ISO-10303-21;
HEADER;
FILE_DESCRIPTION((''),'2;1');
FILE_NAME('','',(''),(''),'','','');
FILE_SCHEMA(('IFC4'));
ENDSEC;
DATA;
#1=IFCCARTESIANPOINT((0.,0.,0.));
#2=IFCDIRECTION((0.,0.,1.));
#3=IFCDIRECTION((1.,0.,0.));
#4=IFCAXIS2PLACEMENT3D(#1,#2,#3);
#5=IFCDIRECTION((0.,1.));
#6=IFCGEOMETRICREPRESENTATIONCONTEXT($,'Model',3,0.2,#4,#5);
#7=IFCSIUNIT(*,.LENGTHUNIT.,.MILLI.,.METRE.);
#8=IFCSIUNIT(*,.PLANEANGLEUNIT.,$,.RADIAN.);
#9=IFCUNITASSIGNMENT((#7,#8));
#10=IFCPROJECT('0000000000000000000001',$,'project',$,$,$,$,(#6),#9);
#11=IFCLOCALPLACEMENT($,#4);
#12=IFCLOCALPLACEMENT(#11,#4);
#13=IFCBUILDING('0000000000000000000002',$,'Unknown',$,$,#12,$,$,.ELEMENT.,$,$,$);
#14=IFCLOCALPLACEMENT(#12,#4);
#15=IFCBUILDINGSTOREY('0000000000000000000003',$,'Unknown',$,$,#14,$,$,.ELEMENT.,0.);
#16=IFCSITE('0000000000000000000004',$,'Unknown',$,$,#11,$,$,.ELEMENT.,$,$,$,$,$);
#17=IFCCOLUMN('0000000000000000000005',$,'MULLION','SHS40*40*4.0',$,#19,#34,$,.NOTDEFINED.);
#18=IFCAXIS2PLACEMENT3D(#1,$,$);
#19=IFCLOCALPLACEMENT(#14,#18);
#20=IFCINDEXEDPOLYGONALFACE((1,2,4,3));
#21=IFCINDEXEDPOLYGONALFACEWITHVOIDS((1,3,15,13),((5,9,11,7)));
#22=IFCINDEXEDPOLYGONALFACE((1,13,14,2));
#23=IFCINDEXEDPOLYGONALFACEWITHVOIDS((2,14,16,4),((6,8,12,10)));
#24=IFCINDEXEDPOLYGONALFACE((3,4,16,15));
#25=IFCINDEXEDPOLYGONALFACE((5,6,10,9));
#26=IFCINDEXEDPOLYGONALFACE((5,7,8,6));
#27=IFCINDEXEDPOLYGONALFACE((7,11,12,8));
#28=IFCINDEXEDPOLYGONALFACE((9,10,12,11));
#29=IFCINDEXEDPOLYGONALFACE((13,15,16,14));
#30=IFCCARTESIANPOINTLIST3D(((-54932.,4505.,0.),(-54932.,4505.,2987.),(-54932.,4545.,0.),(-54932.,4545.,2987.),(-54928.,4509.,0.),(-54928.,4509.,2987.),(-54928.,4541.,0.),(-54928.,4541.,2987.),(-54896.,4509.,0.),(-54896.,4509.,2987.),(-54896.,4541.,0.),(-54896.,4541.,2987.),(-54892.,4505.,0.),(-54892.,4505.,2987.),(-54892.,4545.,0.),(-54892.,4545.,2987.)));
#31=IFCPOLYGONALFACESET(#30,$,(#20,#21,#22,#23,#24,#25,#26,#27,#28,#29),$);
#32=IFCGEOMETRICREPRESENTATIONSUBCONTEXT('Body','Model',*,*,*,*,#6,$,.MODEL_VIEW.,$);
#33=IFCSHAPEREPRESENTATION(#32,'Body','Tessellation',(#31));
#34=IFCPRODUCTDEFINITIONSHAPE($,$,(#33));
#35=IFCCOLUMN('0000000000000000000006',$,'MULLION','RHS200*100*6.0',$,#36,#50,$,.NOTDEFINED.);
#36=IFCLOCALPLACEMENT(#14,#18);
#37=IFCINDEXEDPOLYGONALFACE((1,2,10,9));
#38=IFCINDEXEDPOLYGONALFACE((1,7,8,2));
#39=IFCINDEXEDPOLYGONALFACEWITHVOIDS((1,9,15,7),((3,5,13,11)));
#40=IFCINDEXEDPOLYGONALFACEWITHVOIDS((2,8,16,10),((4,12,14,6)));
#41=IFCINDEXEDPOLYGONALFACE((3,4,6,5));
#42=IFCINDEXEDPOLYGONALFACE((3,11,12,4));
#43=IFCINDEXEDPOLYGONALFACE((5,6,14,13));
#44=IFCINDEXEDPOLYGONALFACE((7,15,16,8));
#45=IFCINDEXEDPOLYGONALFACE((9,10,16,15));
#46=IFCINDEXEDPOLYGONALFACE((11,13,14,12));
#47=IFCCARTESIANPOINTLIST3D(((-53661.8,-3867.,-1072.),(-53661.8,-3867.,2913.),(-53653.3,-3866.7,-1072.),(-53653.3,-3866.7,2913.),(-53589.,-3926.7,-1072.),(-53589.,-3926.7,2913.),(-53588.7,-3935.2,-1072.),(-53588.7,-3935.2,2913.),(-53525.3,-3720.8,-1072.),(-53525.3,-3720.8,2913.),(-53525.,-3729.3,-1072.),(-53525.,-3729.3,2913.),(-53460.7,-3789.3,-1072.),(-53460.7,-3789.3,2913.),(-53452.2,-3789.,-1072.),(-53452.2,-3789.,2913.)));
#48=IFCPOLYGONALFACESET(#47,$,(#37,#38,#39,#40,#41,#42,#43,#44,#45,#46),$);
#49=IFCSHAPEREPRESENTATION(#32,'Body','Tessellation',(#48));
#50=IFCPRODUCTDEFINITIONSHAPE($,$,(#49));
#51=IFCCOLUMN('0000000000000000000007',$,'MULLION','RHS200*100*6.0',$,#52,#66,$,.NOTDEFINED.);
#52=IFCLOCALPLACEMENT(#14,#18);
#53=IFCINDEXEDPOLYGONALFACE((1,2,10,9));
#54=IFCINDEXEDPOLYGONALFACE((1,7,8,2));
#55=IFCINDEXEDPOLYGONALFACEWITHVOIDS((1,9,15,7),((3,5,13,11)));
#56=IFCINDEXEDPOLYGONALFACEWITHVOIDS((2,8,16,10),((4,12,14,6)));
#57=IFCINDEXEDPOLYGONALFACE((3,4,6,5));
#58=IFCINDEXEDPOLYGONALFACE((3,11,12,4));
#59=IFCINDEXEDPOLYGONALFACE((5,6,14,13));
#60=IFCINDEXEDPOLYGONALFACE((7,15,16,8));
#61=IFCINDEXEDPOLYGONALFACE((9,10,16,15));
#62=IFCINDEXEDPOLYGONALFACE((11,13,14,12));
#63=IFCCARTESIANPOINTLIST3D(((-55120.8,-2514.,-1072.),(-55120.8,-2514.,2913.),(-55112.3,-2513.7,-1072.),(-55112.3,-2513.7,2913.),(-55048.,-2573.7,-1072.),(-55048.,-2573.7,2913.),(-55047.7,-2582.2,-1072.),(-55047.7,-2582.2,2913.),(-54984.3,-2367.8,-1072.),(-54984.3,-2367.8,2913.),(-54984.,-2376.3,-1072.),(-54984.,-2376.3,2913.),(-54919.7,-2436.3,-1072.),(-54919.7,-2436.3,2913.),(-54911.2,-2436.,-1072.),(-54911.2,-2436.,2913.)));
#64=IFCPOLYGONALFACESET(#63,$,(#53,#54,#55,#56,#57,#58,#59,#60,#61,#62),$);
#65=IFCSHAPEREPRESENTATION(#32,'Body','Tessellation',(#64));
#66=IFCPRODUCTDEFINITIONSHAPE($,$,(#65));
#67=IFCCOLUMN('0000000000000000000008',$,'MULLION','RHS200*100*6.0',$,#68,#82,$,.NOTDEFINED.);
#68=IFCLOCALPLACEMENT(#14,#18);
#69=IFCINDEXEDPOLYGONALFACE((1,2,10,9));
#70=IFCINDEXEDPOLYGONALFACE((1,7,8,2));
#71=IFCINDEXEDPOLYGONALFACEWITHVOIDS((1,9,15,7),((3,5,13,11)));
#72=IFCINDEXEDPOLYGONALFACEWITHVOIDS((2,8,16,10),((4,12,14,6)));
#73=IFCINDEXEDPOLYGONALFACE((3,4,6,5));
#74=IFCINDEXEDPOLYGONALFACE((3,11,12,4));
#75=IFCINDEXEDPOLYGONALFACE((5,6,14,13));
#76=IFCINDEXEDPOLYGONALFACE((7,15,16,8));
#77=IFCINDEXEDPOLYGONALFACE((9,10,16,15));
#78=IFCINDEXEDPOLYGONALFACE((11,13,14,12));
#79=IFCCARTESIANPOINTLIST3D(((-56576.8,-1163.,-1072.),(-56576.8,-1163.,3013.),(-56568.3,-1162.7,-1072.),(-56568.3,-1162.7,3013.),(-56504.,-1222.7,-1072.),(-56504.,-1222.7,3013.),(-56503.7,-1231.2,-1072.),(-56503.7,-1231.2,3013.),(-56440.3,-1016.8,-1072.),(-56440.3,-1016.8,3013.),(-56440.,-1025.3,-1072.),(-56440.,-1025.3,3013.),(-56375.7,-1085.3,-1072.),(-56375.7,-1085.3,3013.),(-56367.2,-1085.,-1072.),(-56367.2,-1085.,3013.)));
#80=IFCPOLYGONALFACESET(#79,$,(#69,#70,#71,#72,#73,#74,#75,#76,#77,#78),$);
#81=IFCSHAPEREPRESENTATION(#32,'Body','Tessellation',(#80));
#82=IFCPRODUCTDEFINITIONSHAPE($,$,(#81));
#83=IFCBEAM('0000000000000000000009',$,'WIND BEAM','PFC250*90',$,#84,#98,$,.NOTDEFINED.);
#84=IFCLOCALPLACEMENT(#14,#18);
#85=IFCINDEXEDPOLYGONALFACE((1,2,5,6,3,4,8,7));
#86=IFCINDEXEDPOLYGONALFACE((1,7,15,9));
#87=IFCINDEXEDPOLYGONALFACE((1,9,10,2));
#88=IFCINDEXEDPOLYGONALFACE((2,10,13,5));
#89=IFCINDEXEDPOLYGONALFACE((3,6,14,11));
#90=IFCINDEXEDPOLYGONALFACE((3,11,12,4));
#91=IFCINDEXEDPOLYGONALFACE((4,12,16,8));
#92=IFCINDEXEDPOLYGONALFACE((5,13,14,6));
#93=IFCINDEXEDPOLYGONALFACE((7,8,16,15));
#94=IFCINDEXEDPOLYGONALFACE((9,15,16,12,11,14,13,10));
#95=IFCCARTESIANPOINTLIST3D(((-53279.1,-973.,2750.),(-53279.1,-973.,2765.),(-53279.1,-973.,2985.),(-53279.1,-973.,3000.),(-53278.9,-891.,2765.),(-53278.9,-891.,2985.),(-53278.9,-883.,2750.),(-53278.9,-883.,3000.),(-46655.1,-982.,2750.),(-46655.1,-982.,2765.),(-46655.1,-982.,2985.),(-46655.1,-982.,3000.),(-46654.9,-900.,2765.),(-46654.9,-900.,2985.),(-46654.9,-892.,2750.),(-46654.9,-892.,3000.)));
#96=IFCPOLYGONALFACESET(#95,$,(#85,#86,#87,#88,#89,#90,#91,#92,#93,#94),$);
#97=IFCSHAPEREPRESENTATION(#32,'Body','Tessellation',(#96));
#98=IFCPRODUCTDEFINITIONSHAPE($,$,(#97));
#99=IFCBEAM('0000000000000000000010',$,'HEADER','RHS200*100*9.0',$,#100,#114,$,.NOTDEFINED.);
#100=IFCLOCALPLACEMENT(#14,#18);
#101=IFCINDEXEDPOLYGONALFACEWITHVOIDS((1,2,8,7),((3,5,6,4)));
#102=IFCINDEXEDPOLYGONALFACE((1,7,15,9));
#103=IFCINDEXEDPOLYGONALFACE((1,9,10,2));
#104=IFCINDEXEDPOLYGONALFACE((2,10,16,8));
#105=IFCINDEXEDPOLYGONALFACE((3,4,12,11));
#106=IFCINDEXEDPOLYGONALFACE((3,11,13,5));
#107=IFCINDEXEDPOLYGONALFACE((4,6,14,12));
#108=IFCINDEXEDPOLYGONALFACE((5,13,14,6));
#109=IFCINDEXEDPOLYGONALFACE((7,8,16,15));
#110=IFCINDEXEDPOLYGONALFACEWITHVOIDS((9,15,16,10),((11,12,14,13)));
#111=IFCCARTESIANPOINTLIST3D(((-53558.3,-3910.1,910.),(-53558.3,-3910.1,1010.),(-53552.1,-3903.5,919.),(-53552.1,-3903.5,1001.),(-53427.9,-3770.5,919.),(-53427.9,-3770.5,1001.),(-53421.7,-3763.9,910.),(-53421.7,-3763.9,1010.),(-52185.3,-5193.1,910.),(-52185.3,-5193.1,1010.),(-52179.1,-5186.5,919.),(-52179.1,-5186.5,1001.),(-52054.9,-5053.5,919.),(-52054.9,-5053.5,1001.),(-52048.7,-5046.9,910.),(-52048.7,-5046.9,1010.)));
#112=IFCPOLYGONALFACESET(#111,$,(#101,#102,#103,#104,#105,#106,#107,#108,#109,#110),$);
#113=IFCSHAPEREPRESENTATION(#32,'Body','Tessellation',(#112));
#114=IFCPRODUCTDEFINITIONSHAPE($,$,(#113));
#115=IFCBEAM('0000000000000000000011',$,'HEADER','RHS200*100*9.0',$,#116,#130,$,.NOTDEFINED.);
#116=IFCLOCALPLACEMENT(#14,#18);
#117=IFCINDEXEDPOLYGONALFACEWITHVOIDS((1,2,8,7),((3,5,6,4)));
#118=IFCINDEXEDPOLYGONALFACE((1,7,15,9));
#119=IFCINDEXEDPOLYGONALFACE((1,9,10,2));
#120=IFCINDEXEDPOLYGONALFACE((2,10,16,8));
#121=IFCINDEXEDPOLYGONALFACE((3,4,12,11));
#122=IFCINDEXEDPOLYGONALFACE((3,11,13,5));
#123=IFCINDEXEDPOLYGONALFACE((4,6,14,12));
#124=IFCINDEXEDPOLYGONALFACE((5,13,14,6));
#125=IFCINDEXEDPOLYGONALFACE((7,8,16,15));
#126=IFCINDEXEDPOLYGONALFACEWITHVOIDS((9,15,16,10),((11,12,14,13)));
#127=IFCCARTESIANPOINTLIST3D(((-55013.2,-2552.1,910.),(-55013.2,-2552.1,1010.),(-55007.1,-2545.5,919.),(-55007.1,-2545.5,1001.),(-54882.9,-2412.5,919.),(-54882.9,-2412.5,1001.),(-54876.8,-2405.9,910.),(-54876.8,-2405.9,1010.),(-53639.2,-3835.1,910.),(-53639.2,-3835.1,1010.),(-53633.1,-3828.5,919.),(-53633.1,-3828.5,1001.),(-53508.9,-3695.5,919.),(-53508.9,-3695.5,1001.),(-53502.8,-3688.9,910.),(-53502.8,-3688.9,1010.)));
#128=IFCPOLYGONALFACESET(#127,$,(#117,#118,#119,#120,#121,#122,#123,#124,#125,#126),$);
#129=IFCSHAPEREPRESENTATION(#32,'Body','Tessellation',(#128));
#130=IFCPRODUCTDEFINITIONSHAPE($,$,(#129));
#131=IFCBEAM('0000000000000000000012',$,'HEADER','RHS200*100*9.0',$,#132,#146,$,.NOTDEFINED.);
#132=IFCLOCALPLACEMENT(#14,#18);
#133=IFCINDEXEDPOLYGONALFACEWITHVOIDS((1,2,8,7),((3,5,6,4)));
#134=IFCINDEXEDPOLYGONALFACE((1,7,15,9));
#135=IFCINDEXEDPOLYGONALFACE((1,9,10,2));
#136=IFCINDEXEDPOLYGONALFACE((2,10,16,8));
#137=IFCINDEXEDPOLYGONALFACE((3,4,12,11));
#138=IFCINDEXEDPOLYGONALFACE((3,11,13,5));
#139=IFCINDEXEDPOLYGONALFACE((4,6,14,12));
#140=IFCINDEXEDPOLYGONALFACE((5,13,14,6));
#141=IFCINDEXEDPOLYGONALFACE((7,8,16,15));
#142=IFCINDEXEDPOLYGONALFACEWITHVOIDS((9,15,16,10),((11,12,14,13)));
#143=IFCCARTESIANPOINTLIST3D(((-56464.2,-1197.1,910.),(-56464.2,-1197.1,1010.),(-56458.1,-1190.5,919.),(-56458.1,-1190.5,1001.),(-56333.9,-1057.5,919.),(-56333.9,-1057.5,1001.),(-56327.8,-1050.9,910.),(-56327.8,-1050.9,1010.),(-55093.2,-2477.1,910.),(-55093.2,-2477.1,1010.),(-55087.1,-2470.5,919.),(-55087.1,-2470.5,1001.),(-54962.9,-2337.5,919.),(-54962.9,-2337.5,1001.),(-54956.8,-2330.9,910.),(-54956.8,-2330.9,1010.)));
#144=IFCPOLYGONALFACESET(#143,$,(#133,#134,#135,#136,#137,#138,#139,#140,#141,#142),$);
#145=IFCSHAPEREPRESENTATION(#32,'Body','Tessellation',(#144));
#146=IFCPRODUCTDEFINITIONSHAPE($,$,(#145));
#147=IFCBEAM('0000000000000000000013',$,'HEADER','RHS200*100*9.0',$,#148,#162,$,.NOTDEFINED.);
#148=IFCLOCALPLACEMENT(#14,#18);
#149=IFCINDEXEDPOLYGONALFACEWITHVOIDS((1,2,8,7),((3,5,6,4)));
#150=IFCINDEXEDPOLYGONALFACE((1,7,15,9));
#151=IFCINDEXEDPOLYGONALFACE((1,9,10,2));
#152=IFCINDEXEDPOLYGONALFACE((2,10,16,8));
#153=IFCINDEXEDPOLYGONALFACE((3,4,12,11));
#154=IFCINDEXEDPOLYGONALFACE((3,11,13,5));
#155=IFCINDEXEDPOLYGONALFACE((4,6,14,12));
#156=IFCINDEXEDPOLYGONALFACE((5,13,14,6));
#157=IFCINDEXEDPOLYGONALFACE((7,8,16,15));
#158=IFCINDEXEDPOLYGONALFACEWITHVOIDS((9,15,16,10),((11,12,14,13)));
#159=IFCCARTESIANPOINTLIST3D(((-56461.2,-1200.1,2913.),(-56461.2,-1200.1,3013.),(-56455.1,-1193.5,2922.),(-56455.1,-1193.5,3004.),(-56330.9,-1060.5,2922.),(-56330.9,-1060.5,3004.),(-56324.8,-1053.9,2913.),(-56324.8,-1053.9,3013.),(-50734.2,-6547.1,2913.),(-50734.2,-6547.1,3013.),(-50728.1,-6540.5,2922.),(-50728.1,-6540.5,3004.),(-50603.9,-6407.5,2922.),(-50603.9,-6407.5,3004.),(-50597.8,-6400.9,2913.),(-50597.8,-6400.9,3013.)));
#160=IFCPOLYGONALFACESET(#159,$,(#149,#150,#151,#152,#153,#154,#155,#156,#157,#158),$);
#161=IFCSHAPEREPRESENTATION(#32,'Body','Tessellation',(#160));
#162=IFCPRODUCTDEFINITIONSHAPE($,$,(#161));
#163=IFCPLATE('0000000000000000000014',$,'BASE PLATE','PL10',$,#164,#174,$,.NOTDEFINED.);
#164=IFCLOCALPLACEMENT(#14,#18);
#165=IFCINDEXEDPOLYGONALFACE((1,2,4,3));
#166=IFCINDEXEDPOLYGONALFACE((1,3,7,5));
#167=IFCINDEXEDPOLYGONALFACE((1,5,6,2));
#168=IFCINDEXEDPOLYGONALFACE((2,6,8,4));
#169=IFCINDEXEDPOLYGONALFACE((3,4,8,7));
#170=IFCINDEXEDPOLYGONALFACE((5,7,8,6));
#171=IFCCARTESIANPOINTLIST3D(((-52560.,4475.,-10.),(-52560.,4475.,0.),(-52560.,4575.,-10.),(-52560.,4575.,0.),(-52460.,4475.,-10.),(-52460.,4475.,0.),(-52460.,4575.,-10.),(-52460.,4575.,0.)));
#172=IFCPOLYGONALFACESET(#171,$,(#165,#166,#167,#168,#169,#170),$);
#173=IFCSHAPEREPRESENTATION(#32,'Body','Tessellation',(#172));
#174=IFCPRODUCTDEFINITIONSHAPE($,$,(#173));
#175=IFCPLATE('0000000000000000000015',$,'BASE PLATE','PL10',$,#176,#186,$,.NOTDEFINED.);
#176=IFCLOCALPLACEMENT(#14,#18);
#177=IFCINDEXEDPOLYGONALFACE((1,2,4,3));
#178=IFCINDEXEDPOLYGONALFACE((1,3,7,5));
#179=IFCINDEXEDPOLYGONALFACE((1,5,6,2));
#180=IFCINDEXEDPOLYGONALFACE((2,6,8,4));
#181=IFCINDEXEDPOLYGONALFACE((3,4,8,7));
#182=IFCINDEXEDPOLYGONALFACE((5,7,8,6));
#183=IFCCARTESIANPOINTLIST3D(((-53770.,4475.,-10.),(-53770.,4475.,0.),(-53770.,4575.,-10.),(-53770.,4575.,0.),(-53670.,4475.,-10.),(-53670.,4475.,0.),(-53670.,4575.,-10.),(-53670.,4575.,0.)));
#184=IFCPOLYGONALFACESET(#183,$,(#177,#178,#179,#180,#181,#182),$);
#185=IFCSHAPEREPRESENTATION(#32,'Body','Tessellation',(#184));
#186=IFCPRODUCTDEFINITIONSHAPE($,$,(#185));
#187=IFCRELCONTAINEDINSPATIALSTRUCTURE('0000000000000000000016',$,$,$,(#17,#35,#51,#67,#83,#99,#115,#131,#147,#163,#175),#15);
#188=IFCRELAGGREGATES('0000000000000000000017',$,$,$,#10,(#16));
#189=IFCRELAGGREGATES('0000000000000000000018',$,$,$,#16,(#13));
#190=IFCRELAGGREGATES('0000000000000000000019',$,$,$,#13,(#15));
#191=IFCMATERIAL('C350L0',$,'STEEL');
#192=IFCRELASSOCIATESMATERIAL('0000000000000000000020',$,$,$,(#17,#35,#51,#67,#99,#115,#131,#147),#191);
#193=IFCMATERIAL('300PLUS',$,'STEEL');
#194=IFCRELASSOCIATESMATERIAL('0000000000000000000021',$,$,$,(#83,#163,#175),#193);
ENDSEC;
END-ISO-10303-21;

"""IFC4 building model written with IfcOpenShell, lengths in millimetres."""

from ifc_helpers import new_model, si_unit, direction, frame, origin_with_axes, place, context, subcontext, project, spatial, line, indexed_curve, outline, extrude, material, element, save


model = new_model("IFC4")

# Units and contexts
model_context = context("Model", 3, precision=0.2, world=origin_with_axes(), true_north=direction((0.0, 1.0)))
body_context = subcontext(model_context, "Body", "Model", "MODEL_VIEW")
ifc_project = project(units=[si_unit("LENGTHUNIT", "METRE", prefix="MILLI"), si_unit("PLANEANGLEUNIT", "RADIAN")], contexts=[model_context])

# Site, building, storey
site_placement = place(None, origin_with_axes())
site = spatial("IfcSite", under=ifc_project, at=site_placement, Name="Unknown", CompositionType="ELEMENT")
building_placement = place(site_placement, origin_with_axes())
building = spatial("IfcBuilding", under=site, at=building_placement, Name="Unknown", CompositionType="ELEMENT")
storey_placement = place(building_placement, origin_with_axes())
storey = spatial("IfcBuildingStorey", under=building, at=storey_placement, Name="Unknown", CompositionType="ELEMENT", Elevation=0.0)

# Columns
ifc_material_1 = material(Name="C350L0", Category="STEEL")
column_1_placement = place(storey_placement, frame((-54912.0, 4525.0, 0.0), z_axis=(0.000017, -1.0, 0.0), x_axis=(0.0, 0.0, 1.0)))
element("IfcColumn", 1, at=column_1_placement, inside=storey, material=ifc_material_1, Name="MULLION", Description="SHS40*40*4.0", PredefinedType="NOTDEFINED", context=body_context, shape_type="SolidModel", body=[
    extrude(outline(indexed_curve([(-20.0, -20.0), (20.0, -20.0), (20.0, 20.0), (-20.0, 20.0)], segments=[line(1, 2, 3, 4, 1)]), holes=[indexed_curve([(-16.0, -16.0), (-16.0, 16.0), (16.0, 16.0), (16.0, -16.0)], segments=[line(1, 2, 3, 4, 1)])]), frame((0.0, 0.0, 0.0), z_axis=(-1.0, 0.0, 0.0), x_axis=(0.0, 0.0, 1.0)), (0.0, 0.0, -1.0), 2987.0),
])
for number, where, z_axis, x_axis, name in (
    (2, (-53557.0, -3828.0, -1072.0), (0.730997, -0.682381, 0.0), (0.0, 0.0, 1.0), "MULLION"),
    (3, (-55016.0, -2475.0, -1072.0), (0.730997, -0.682381, 0.0), (0.0, 0.0, 1.0), "MULLION"),
):
    element("IfcColumn", number, at=place(storey_placement, frame(where, z_axis=z_axis, x_axis=x_axis)), inside=storey, material=ifc_material_1, Name=name, Description="RHS200*100*6.0", PredefinedType="NOTDEFINED", context=body_context, shape_type="SolidModel", body=[
        extrude(outline(indexed_curve([(-50.0, -100.0), (50.0, -100.0), (50.0, 100.0), (-50.0, 100.0)], segments=[line(1, 2, 3, 4, 1)]), holes=[indexed_curve([(-44.0, -94.0), (-44.0, 94.0), (44.0, 94.0), (44.0, -94.0)], segments=[line(1, 2, 3, 4, 1)])]), frame((0.0, 0.0, 0.0), z_axis=(-1.0, 0.0, 0.0), x_axis=(0.0, 0.0, 1.0)), (0.0, 0.0, -1.0), 3985.0),
    ])
column_2_placement = place(storey_placement, frame((-56472.0, -1124.0, -1072.0), z_axis=(0.730997, -0.682381, 0.0), x_axis=(0.0, 0.0, 1.0)))
element("IfcColumn", 4, at=column_2_placement, inside=storey, material=ifc_material_1, Name="MULLION", Description="RHS200*100*6.0", PredefinedType="NOTDEFINED", context=body_context, shape_type="SolidModel", body=[
    extrude(outline(indexed_curve([(-50.0, -100.0), (50.0, -100.0), (50.0, 100.0), (-50.0, 100.0)], segments=[line(1, 2, 3, 4, 1)]), holes=[indexed_curve([(-44.0, -94.0), (-44.0, 94.0), (44.0, 94.0), (44.0, -94.0)], segments=[line(1, 2, 3, 4, 1)])]), frame((0.0, 0.0, 0.0), z_axis=(-1.0, 0.0, 0.0), x_axis=(0.0, 0.0, 1.0)), (0.0, 0.0, -1.0), 4085.0),
])

# Beams
ifc_material_2 = material(Name="300PLUS", Category="STEEL")
beam_1_placement = place(storey_placement, frame((-53279.0, -928.0, 2875.0), z_axis=(-0.001359, -0.999999, 0.0), x_axis=(0.999999, -0.001359, 0.0)))
element("IfcBeam", 5, at=beam_1_placement, inside=storey, material=ifc_material_2, Name="WIND BEAM", Description="PFC250*90", PredefinedType="NOTDEFINED", context=body_context, shape_type="SolidModel", body=[
    extrude(outline(indexed_curve([(-45.0, -125.0), (45.0, -125.0), (45.0, -110.0), (-37.0, -110.0), (-37.0, 110.0), (45.0, 110.0), (45.0, 125.0), (-45.0, 125.0)], segments=[line(1, 2, 3, 4, 5, 6, 7, 8, 1)])), frame((0.0, 0.0, 0.0), z_axis=(-1.0, 0.0, 0.0), x_axis=(0.0, 0.0, 1.0)), (0.0, 0.0, -1.0), 6624.0),
])
beam_2_placement = place(storey_placement, frame((-53490.0, -3837.0, 960.0), z_axis=(0.0, 0.0, 1.0), x_axis=(0.730648, -0.682754, 0.0)))
element("IfcBeam", 6, at=beam_2_placement, inside=storey, material=ifc_material_1, Name="HEADER", Description="RHS200*100*9.0", PredefinedType="NOTDEFINED", context=body_context, shape_type="SolidModel", body=[
    extrude(outline(indexed_curve([(-50.0, -100.0), (50.0, -100.0), (50.0, 100.0), (-50.0, 100.0)], segments=[line(1, 2, 3, 4, 1)]), holes=[indexed_curve([(-41.0, -91.0), (-41.0, 91.0), (41.0, 91.0), (41.0, -91.0)], segments=[line(1, 2, 3, 4, 1)])]), frame((0.0, 0.0, 0.0), z_axis=(-1.0, 0.0, 0.0), x_axis=(0.0, 0.0, 1.0)), (0.0, 0.0, -1.0), 1879.2),
])
beam_3_placement = place(storey_placement, frame((-54945.0, -2479.0, 960.0), z_axis=(0.0, 0.0, 1.0), x_axis=(0.730896, -0.682489, 0.0)))
element("IfcBeam", 7, at=beam_3_placement, inside=storey, material=ifc_material_1, Name="HEADER", Description="RHS200*100*9.0", PredefinedType="NOTDEFINED", context=body_context, shape_type="SolidModel", body=[
    extrude(outline(indexed_curve([(-50.0, -100.0), (50.0, -100.0), (50.0, 100.0), (-50.0, 100.0)], segments=[line(1, 2, 3, 4, 1)]), holes=[indexed_curve([(-41.0, -91.0), (-41.0, 91.0), (41.0, 91.0), (41.0, -91.0)], segments=[line(1, 2, 3, 4, 1)])]), frame((0.0, 0.0, 0.0), z_axis=(-1.0, 0.0, 0.0), x_axis=(0.0, 0.0, 1.0)), (0.0, 0.0, -1.0), 1879.9),
])
beam_4_placement = place(storey_placement, frame((-56396.0, -1124.0, 960.0), z_axis=(0.0, 0.0, 1.0), x_axis=(0.730949, -0.682432, 0.0)))
element("IfcBeam", 8, at=beam_4_placement, inside=storey, material=ifc_material_1, Name="HEADER", Description="RHS200*100*9.0", PredefinedType="NOTDEFINED", context=body_context, shape_type="SolidModel", body=[
    extrude(outline(indexed_curve([(-50.0, -100.0), (50.0, -100.0), (50.0, 100.0), (-50.0, 100.0)], segments=[line(1, 2, 3, 4, 1)]), holes=[indexed_curve([(-41.0, -91.0), (-41.0, 91.0), (41.0, 91.0), (41.0, -91.0)], segments=[line(1, 2, 3, 4, 1)])]), frame((0.0, 0.0, 0.0), z_axis=(-1.0, 0.0, 0.0), x_axis=(0.0, 0.0, 1.0)), (0.0, 0.0, -1.0), 1875.6),
])
beam_5_placement = place(storey_placement, frame((-56393.0, -1127.0, 2963.0), z_axis=(0.0, 0.0, 1.0), x_axis=(0.730941, -0.682441, 0.0)))
element("IfcBeam", 9, at=beam_5_placement, inside=storey, material=ifc_material_1, Name="HEADER", Description="RHS200*100*9.0", PredefinedType="NOTDEFINED", context=body_context, shape_type="SolidModel", body=[
    extrude(outline(indexed_curve([(-50.0, -100.0), (50.0, -100.0), (50.0, 100.0), (-50.0, 100.0)], segments=[line(1, 2, 3, 4, 1)]), holes=[indexed_curve([(-41.0, -91.0), (-41.0, 91.0), (41.0, 91.0), (41.0, -91.0)], segments=[line(1, 2, 3, 4, 1)])]), frame((0.0, 0.0, 0.0), z_axis=(-1.0, 0.0, 0.0), x_axis=(0.0, 0.0, 1.0)), (0.0, 0.0, -1.0), 7835.1),
])

# Plates
for number, where, z_axis, x_axis, name in (
    (10, (-52560.0, 4475.0, -5.0), (0.0, 0.0, 1.0), (1.0, 0.0, 0.0), "BASE PLATE"),
    (11, (-53770.0, 4475.0, -5.0), (0.0, 0.0, 1.0), (1.0, 0.0, 0.0), "BASE PLATE"),
):
    element("IfcPlate", number, at=place(storey_placement, frame(where, z_axis=z_axis, x_axis=x_axis)), inside=storey, material=ifc_material_2, Name=name, Description="PL10", PredefinedType="NOTDEFINED", context=body_context, shape_type="SolidModel", body=[
        extrude(outline(indexed_curve([(0.0, 0.0), (100.0, 0.0), (100.0, 100.0), (0.0, 100.0)], segments=[line(1, 2, 3, 4, 1)])), frame((0.0, 0.0, 5.0), z_axis=(0.0, 0.0, 1.0), x_axis=(1.0, 0.0, 0.0)), (0.0, 0.0, -1.0), 10.0),
    ])

save(model, "model.ifc")
